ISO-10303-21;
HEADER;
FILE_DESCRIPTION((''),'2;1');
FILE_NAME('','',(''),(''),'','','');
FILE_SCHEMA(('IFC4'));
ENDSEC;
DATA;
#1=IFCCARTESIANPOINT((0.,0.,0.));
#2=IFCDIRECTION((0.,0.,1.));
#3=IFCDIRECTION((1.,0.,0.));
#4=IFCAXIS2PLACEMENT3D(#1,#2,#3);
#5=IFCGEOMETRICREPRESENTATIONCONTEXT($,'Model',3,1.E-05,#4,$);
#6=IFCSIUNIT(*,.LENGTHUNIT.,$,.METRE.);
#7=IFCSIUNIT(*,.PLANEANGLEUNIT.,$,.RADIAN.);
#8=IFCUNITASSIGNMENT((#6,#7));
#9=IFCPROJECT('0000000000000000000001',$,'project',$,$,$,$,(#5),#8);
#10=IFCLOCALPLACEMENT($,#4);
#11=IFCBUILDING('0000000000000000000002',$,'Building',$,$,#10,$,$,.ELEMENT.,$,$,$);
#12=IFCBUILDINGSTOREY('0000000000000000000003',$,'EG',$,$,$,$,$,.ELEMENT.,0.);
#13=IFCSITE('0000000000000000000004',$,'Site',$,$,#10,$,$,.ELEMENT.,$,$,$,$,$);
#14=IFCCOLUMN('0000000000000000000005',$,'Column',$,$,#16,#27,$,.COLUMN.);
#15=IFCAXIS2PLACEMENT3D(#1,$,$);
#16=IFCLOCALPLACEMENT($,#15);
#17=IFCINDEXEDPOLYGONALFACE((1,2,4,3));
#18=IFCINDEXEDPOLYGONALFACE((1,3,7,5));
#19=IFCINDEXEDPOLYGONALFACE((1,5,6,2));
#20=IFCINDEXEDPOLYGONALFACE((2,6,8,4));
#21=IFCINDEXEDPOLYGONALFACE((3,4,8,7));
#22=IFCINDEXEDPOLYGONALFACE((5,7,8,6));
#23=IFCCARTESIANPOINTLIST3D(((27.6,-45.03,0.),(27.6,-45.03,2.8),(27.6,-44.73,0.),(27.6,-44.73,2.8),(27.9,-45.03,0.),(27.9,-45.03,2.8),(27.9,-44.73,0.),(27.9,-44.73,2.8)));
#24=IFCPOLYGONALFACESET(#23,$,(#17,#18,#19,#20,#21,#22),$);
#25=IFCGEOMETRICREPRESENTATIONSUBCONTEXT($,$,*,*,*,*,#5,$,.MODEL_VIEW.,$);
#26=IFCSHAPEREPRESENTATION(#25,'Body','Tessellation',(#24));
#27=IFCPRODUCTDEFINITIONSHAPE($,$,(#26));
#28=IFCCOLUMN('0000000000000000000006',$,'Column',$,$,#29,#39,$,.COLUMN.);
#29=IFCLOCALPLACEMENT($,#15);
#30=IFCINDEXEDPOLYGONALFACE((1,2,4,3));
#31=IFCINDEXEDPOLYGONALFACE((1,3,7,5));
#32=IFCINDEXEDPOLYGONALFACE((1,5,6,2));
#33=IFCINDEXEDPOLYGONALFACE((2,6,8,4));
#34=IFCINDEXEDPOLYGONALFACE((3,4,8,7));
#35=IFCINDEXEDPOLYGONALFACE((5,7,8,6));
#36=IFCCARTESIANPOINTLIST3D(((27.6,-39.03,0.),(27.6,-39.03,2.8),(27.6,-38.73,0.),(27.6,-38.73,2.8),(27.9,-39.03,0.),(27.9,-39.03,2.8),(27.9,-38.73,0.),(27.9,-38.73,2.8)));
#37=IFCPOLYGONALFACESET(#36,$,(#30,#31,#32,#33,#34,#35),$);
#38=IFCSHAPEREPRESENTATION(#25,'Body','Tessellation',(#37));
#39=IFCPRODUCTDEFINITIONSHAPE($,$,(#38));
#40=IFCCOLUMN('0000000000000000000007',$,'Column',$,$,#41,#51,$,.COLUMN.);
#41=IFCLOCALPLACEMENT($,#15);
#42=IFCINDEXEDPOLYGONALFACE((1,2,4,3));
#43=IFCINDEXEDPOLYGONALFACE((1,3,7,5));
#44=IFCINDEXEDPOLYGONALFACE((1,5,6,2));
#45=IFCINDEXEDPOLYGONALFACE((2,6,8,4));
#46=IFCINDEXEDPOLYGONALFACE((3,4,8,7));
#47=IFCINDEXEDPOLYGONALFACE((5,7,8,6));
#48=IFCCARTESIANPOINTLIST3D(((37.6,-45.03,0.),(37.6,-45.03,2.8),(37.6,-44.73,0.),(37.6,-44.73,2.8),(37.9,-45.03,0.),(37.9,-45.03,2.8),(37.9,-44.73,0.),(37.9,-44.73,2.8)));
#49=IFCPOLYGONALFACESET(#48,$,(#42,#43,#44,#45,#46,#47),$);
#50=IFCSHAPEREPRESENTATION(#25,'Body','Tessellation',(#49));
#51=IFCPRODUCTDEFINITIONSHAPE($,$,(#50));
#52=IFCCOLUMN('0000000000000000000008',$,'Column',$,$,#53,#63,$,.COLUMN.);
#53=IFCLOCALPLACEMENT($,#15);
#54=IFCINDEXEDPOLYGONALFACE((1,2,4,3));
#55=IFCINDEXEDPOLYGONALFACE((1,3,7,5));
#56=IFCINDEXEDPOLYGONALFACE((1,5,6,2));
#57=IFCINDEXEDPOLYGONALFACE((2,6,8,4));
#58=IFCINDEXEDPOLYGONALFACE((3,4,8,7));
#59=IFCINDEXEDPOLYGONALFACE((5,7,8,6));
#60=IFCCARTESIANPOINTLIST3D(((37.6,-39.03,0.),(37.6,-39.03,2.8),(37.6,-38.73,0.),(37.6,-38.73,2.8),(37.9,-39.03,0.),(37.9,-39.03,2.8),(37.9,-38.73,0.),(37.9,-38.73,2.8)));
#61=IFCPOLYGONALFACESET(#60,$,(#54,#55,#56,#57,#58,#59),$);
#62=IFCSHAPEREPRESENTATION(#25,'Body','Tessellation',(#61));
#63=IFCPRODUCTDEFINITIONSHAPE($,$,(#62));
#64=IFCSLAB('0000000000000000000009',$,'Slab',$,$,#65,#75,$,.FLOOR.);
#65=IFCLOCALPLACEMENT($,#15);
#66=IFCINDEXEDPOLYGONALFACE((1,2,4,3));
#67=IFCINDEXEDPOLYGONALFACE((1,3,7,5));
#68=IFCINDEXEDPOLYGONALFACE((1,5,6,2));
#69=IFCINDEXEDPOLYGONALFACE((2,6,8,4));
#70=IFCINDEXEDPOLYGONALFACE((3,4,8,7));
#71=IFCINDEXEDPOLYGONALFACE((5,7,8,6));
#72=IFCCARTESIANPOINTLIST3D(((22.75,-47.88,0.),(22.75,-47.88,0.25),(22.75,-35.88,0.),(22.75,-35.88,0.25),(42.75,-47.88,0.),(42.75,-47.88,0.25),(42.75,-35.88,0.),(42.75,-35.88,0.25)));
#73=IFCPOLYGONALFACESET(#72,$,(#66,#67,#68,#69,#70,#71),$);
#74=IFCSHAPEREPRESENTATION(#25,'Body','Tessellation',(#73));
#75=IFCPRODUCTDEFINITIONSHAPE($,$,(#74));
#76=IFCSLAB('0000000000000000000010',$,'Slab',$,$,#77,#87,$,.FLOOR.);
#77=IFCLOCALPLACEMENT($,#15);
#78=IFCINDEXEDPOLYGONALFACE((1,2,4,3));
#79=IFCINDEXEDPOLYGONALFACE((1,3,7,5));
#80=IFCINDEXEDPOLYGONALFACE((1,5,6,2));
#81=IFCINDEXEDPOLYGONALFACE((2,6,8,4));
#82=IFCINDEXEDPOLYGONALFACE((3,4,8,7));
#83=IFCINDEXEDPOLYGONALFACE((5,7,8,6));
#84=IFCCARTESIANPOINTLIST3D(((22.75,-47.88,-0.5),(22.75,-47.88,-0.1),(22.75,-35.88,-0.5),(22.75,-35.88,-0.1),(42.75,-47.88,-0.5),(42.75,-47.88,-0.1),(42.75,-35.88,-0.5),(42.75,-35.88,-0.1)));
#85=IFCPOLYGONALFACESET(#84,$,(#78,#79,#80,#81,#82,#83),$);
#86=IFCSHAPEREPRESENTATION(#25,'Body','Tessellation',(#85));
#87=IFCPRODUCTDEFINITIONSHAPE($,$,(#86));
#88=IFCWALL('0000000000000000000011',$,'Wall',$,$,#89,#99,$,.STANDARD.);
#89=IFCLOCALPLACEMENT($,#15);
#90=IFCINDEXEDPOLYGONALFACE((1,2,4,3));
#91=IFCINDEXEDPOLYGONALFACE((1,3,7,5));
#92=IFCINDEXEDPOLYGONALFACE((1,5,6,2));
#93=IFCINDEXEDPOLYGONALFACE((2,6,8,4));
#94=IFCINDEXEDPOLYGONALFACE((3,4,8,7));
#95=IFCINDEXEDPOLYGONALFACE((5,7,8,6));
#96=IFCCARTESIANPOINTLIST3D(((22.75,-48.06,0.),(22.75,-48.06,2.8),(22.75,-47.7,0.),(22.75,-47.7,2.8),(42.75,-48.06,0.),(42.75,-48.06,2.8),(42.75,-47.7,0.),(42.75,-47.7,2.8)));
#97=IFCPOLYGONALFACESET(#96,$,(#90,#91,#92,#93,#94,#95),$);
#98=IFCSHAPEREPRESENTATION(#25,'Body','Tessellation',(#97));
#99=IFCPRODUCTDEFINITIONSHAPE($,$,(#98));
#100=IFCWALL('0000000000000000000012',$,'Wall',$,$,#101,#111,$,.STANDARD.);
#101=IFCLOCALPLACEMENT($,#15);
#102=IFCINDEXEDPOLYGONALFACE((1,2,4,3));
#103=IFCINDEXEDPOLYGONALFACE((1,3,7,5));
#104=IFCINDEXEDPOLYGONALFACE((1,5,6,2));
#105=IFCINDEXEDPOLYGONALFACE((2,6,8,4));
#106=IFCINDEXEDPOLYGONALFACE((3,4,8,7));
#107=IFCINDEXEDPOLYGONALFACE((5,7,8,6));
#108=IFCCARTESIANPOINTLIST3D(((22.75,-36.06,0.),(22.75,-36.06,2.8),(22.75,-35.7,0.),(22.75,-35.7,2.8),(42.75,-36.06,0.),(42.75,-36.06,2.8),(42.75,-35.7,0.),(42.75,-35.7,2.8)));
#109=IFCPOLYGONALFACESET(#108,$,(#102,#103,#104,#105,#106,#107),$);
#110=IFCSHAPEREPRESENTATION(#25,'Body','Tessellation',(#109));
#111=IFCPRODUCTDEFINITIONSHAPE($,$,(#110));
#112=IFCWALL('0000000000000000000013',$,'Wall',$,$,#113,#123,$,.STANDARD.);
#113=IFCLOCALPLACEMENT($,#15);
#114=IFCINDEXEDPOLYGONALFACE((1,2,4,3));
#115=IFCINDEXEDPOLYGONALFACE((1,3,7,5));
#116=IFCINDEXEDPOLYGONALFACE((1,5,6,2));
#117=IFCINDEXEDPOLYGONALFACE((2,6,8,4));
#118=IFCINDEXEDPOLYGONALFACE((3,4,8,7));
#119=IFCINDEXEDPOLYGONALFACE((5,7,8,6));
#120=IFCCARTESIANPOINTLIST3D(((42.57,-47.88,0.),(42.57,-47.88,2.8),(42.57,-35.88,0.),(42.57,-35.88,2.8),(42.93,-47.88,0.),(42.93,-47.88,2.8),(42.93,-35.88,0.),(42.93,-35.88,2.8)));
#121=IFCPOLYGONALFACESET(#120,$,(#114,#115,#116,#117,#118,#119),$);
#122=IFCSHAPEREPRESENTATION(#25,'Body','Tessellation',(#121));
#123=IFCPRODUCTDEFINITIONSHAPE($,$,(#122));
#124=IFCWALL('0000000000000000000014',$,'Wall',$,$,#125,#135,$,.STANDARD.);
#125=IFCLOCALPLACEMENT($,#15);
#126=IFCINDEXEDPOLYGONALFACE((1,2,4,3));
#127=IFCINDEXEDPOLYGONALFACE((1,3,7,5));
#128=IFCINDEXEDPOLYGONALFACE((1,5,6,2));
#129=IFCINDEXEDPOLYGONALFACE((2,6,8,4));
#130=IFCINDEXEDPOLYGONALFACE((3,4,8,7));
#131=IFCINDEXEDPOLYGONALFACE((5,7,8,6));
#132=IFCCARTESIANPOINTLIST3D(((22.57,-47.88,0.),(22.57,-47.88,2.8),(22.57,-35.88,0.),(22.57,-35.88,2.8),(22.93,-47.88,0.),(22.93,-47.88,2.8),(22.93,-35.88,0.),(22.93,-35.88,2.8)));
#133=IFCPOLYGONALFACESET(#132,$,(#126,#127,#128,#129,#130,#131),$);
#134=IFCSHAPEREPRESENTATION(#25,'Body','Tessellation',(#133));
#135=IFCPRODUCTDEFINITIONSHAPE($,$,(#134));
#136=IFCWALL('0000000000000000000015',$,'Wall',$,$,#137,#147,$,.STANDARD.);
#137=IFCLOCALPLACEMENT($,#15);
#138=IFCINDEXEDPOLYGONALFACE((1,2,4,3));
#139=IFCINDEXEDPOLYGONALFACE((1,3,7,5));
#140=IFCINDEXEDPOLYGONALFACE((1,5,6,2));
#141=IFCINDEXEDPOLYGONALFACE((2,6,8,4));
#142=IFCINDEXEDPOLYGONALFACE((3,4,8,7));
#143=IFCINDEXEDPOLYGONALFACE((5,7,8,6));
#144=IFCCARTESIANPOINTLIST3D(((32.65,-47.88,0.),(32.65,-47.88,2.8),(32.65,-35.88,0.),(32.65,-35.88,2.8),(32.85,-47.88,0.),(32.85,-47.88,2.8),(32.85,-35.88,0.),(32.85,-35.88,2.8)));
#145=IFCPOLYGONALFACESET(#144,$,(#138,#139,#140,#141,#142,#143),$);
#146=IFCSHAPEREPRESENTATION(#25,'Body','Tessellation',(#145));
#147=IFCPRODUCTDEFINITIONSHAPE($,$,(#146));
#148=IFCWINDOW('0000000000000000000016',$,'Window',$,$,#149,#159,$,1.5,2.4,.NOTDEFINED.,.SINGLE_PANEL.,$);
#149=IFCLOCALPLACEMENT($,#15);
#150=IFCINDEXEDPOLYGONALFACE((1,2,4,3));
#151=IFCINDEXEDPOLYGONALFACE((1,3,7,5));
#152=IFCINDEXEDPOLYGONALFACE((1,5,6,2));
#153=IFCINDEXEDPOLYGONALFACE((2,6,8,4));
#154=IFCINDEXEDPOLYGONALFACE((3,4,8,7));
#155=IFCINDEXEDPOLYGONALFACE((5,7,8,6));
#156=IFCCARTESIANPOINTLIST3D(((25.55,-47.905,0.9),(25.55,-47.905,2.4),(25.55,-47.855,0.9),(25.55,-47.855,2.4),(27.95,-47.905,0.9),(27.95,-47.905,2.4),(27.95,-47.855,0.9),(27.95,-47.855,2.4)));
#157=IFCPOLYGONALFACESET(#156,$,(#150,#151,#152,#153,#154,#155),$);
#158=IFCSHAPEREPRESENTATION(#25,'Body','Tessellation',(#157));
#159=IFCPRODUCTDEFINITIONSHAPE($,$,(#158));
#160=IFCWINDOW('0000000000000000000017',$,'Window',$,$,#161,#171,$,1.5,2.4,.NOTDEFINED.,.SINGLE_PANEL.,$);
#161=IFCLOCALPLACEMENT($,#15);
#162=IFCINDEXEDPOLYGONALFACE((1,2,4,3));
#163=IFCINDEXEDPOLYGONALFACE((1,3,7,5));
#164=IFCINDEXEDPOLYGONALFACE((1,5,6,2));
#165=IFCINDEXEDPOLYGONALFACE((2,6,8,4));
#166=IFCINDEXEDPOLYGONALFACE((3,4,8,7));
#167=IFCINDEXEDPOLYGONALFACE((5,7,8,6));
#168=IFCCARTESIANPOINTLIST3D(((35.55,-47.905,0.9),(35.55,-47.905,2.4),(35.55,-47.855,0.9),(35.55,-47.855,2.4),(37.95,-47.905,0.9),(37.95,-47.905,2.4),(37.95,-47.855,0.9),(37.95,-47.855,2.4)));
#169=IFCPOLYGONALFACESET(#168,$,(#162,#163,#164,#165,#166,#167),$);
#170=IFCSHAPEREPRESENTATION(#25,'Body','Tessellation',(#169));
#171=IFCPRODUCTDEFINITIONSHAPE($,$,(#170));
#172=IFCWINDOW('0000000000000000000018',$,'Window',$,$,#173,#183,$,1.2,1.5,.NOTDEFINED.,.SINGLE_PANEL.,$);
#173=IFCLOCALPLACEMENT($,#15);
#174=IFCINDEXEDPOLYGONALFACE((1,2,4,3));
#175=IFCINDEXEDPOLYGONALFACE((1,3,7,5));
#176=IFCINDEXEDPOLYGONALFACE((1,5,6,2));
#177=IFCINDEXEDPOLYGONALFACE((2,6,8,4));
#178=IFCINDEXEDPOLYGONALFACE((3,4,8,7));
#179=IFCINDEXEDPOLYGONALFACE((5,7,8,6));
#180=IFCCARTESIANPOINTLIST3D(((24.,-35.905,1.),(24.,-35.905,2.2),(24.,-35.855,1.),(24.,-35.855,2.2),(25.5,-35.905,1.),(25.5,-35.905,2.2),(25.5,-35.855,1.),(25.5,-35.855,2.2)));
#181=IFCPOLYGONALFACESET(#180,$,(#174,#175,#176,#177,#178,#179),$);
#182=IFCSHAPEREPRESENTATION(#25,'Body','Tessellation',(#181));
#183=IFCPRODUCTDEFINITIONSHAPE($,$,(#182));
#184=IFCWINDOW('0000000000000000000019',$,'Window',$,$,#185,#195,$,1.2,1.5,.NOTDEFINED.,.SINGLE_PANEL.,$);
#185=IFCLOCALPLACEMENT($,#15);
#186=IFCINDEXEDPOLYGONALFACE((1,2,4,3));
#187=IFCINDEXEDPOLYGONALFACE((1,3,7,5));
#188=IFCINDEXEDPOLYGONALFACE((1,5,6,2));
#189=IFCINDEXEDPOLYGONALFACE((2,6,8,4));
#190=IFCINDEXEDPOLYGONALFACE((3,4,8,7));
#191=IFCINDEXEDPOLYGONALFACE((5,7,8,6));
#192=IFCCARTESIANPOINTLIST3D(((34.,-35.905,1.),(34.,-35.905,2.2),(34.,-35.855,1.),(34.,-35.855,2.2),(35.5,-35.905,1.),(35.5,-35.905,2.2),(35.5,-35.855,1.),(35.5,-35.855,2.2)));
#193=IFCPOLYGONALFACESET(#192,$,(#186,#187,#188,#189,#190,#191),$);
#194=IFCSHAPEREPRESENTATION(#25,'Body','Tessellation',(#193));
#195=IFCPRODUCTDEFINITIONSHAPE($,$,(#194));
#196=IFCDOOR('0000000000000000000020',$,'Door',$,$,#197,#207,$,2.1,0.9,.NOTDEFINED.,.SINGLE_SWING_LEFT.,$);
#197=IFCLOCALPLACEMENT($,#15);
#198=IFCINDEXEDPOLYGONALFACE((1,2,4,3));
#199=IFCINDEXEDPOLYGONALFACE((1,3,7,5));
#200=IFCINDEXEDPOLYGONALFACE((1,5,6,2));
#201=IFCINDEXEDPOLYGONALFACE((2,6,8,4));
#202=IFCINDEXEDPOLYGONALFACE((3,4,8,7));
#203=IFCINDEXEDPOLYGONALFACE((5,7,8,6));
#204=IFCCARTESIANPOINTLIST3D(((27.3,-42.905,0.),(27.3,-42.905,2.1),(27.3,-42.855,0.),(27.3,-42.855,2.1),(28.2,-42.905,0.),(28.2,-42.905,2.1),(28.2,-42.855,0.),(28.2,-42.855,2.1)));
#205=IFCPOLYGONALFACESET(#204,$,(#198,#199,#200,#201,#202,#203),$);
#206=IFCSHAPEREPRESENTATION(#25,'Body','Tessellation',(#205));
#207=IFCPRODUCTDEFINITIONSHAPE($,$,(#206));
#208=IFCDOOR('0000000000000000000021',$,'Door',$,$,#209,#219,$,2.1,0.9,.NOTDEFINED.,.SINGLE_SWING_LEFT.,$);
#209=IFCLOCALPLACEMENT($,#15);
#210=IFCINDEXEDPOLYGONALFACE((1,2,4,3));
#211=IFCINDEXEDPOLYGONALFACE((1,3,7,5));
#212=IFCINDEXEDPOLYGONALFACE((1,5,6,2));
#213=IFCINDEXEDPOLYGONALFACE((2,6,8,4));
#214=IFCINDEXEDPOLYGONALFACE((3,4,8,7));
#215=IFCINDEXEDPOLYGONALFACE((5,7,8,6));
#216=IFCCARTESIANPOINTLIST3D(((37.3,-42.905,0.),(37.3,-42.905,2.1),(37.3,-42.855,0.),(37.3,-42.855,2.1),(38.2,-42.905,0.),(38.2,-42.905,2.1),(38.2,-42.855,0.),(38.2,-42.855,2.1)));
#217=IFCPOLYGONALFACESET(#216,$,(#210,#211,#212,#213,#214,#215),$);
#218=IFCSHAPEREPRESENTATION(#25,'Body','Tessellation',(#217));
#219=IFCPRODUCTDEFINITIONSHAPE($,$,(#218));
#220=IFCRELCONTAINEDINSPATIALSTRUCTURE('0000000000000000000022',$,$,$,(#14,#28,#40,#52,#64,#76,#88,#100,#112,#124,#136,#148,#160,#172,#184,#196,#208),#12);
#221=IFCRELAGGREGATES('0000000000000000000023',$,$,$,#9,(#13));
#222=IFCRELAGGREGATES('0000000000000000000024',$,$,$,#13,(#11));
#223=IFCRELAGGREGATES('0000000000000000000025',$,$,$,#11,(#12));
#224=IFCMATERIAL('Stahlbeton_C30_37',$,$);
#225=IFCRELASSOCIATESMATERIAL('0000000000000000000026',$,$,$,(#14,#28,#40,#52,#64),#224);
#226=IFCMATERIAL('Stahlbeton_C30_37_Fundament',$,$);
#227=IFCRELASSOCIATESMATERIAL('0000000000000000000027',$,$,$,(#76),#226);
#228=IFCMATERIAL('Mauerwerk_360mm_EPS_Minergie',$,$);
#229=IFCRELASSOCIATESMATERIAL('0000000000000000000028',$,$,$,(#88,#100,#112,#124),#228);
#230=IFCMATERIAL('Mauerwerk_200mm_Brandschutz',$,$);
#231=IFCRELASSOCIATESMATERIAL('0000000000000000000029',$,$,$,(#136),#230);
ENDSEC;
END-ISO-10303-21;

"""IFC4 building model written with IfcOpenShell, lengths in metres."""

from ifc_helpers import new_model, si_unit, frame, frame_2d, origin, origin_with_axes, origin_2d, place, context, subcontext, project, spatial, rectangle, extrude, material, element, save


model = new_model("IFC4")

# Units and contexts
model_context = context("Model", 3, precision=1e-05, world=origin_with_axes())
sub_context = subcontext(model_context, None, None, "MODEL_VIEW")
ifc_project = project(units=[si_unit("LENGTHUNIT", "METRE"), si_unit("PLANEANGLEUNIT", "RADIAN")], contexts=[model_context])

# Site, building, storey
placement_1 = place(None, origin_with_axes())
site = spatial("IfcSite", under=ifc_project, at=placement_1, Name="Site", CompositionType="ELEMENT")
building = spatial("IfcBuilding", under=site, at=placement_1, Name="Building", CompositionType="ELEMENT")
storey = spatial("IfcBuildingStorey", under=building, Name="EG", CompositionType="ELEMENT", Elevation=0.0)

# Columns
ifc_material_1 = material(Name="Stahlbeton_C30_37")
placement_2 = place(placement_1, origin())
for number, where, name in (
    (1, (27.75, -44.88, 0.0), "Column"),
    (2, (27.75, -38.88, 0.0), "Column"),
    (3, (37.75, -44.88, 0.0), "Column"),
    (4, (37.75, -38.88, 0.0), "Column"),
):
    element("IfcColumn", number, at=place(placement_2, frame(where)), inside=storey, material=ifc_material_1, Name=name, PredefinedType="COLUMN", context=sub_context, shape_type="SweptSolid", body=[
        extrude(rectangle(XDim=0.3, YDim=0.3, at=origin_2d()), origin(), (0.0, 0.0, 1.0), 2.8),
    ])

# Slabs
slab_1_placement = place(placement_2, frame((22.75, -47.88, 0.0)))
element("IfcSlab", 5, at=slab_1_placement, inside=storey, material=ifc_material_1, Name="Slab", PredefinedType="FLOOR", context=sub_context, shape_type="SweptSolid", body=[
    extrude(rectangle(XDim=20.0, YDim=12.0, at=frame_2d((10.0, 6.0))), origin(), (0.0, 0.0, 1.0), 0.25),
])
ifc_material_2 = material(Name="Stahlbeton_C30_37_Fundament")
slab_2_placement = place(placement_2, frame((22.75, -47.88, -0.5)))
element("IfcSlab", 6, at=slab_2_placement, inside=storey, material=ifc_material_2, Name="Slab", PredefinedType="FLOOR", context=sub_context, shape_type="SweptSolid", body=[
    extrude(rectangle(XDim=20.0, YDim=12.0, at=frame_2d((10.0, 6.0))), origin(), (0.0, 0.0, 1.0), 0.4),
])

# Walls
ifc_material_3 = material(Name="Mauerwerk_360mm_EPS_Minergie")
for number, where, x_axis, name in (
    (7, (22.75, -47.88, 0.0), (1.0, 0.0, 0.0), "Wall"),
    (8, (22.75, -35.88, 0.0), (1.0, 0.0, 0.0), "Wall"),
):
    element("IfcWall", number, at=place(placement_2, frame(where, x_axis=x_axis)), inside=storey, material=ifc_material_3, Name=name, PredefinedType="STANDARD", context=sub_context, shape_type="SweptSolid", body=[
        extrude(rectangle(XDim=20.0, YDim=0.36, at=frame_2d((10.0, 0.0))), origin(), (0.0, 0.0, 1.0), 2.8),
    ])
for number, where, x_axis, name in (
    (9, (42.75, -47.88, 0.0), (0.0, 1.0, 0.0), "Wall"),
    (10, (22.75, -47.88, 0.0), (0.0, 1.0, 0.0), "Wall"),
):
    element("IfcWall", number, at=place(placement_2, frame(where, x_axis=x_axis)), inside=storey, material=ifc_material_3, Name=name, PredefinedType="STANDARD", context=sub_context, shape_type="SweptSolid", body=[
        extrude(rectangle(XDim=12.0, YDim=0.36, at=frame_2d((6.0, 0.0))), origin(), (0.0, 0.0, 1.0), 2.8),
    ])
ifc_material_4 = material(Name="Mauerwerk_200mm_Brandschutz")
wall_placement = place(placement_2, frame((32.75, -47.88, 0.0), x_axis=(0.0, 1.0, 0.0)))
element("IfcWall", 11, at=wall_placement, inside=storey, material=ifc_material_4, Name="Wall", PredefinedType="STANDARD", context=sub_context, shape_type="SweptSolid", body=[
    extrude(rectangle(XDim=12.0, YDim=0.2, at=frame_2d((6.0, 0.0))), origin(), (0.0, 0.0, 1.0), 2.8),
])

# Windows
for number, where, name in (
    (12, (26.75, -47.88, 0.9), "Window"),
    (13, (36.75, -47.88, 0.9), "Window"),
):
    element("IfcWindow", number, at=place(placement_1, frame(where)), inside=storey, Name=name, OverallHeight=1.5, OverallWidth=2.4, PartitioningType="SINGLE_PANEL", PredefinedType="NOTDEFINED", context=sub_context, shape_type="SweptSolid", body=[
        extrude(rectangle(XDim=2.4, YDim=0.05, at=origin_2d()), origin(), (0.0, 0.0, 1.0), 1.5),
    ])
for number, where, name in (
    (14, (24.75, -35.88, 1.0), "Window"),
    (15, (34.75, -35.88, 1.0), "Window"),
):
    element("IfcWindow", number, at=place(placement_1, frame(where)), inside=storey, Name=name, OverallHeight=1.2, OverallWidth=1.5, PartitioningType="SINGLE_PANEL", PredefinedType="NOTDEFINED", context=sub_context, shape_type="SweptSolid", body=[
        extrude(rectangle(XDim=1.5, YDim=0.05, at=origin_2d()), origin(), (0.0, 0.0, 1.0), 1.2),
    ])

# Doors
for number, where, name in (
    (16, (27.75, -42.88, 0.0), "Door"),
    (17, (37.75, -42.88, 0.0), "Door"),
):
    element("IfcDoor", number, at=place(placement_1, frame(where)), inside=storey, Name=name, OperationType="SINGLE_SWING_LEFT", OverallHeight=2.1, OverallWidth=0.9, PredefinedType="NOTDEFINED", context=sub_context, shape_type="SweptSolid", body=[
        extrude(rectangle(XDim=0.9, YDim=0.05, at=origin_2d()), origin(), (0.0, 0.0, 1.0), 2.1),
    ])

save(model, "model.ifc")
